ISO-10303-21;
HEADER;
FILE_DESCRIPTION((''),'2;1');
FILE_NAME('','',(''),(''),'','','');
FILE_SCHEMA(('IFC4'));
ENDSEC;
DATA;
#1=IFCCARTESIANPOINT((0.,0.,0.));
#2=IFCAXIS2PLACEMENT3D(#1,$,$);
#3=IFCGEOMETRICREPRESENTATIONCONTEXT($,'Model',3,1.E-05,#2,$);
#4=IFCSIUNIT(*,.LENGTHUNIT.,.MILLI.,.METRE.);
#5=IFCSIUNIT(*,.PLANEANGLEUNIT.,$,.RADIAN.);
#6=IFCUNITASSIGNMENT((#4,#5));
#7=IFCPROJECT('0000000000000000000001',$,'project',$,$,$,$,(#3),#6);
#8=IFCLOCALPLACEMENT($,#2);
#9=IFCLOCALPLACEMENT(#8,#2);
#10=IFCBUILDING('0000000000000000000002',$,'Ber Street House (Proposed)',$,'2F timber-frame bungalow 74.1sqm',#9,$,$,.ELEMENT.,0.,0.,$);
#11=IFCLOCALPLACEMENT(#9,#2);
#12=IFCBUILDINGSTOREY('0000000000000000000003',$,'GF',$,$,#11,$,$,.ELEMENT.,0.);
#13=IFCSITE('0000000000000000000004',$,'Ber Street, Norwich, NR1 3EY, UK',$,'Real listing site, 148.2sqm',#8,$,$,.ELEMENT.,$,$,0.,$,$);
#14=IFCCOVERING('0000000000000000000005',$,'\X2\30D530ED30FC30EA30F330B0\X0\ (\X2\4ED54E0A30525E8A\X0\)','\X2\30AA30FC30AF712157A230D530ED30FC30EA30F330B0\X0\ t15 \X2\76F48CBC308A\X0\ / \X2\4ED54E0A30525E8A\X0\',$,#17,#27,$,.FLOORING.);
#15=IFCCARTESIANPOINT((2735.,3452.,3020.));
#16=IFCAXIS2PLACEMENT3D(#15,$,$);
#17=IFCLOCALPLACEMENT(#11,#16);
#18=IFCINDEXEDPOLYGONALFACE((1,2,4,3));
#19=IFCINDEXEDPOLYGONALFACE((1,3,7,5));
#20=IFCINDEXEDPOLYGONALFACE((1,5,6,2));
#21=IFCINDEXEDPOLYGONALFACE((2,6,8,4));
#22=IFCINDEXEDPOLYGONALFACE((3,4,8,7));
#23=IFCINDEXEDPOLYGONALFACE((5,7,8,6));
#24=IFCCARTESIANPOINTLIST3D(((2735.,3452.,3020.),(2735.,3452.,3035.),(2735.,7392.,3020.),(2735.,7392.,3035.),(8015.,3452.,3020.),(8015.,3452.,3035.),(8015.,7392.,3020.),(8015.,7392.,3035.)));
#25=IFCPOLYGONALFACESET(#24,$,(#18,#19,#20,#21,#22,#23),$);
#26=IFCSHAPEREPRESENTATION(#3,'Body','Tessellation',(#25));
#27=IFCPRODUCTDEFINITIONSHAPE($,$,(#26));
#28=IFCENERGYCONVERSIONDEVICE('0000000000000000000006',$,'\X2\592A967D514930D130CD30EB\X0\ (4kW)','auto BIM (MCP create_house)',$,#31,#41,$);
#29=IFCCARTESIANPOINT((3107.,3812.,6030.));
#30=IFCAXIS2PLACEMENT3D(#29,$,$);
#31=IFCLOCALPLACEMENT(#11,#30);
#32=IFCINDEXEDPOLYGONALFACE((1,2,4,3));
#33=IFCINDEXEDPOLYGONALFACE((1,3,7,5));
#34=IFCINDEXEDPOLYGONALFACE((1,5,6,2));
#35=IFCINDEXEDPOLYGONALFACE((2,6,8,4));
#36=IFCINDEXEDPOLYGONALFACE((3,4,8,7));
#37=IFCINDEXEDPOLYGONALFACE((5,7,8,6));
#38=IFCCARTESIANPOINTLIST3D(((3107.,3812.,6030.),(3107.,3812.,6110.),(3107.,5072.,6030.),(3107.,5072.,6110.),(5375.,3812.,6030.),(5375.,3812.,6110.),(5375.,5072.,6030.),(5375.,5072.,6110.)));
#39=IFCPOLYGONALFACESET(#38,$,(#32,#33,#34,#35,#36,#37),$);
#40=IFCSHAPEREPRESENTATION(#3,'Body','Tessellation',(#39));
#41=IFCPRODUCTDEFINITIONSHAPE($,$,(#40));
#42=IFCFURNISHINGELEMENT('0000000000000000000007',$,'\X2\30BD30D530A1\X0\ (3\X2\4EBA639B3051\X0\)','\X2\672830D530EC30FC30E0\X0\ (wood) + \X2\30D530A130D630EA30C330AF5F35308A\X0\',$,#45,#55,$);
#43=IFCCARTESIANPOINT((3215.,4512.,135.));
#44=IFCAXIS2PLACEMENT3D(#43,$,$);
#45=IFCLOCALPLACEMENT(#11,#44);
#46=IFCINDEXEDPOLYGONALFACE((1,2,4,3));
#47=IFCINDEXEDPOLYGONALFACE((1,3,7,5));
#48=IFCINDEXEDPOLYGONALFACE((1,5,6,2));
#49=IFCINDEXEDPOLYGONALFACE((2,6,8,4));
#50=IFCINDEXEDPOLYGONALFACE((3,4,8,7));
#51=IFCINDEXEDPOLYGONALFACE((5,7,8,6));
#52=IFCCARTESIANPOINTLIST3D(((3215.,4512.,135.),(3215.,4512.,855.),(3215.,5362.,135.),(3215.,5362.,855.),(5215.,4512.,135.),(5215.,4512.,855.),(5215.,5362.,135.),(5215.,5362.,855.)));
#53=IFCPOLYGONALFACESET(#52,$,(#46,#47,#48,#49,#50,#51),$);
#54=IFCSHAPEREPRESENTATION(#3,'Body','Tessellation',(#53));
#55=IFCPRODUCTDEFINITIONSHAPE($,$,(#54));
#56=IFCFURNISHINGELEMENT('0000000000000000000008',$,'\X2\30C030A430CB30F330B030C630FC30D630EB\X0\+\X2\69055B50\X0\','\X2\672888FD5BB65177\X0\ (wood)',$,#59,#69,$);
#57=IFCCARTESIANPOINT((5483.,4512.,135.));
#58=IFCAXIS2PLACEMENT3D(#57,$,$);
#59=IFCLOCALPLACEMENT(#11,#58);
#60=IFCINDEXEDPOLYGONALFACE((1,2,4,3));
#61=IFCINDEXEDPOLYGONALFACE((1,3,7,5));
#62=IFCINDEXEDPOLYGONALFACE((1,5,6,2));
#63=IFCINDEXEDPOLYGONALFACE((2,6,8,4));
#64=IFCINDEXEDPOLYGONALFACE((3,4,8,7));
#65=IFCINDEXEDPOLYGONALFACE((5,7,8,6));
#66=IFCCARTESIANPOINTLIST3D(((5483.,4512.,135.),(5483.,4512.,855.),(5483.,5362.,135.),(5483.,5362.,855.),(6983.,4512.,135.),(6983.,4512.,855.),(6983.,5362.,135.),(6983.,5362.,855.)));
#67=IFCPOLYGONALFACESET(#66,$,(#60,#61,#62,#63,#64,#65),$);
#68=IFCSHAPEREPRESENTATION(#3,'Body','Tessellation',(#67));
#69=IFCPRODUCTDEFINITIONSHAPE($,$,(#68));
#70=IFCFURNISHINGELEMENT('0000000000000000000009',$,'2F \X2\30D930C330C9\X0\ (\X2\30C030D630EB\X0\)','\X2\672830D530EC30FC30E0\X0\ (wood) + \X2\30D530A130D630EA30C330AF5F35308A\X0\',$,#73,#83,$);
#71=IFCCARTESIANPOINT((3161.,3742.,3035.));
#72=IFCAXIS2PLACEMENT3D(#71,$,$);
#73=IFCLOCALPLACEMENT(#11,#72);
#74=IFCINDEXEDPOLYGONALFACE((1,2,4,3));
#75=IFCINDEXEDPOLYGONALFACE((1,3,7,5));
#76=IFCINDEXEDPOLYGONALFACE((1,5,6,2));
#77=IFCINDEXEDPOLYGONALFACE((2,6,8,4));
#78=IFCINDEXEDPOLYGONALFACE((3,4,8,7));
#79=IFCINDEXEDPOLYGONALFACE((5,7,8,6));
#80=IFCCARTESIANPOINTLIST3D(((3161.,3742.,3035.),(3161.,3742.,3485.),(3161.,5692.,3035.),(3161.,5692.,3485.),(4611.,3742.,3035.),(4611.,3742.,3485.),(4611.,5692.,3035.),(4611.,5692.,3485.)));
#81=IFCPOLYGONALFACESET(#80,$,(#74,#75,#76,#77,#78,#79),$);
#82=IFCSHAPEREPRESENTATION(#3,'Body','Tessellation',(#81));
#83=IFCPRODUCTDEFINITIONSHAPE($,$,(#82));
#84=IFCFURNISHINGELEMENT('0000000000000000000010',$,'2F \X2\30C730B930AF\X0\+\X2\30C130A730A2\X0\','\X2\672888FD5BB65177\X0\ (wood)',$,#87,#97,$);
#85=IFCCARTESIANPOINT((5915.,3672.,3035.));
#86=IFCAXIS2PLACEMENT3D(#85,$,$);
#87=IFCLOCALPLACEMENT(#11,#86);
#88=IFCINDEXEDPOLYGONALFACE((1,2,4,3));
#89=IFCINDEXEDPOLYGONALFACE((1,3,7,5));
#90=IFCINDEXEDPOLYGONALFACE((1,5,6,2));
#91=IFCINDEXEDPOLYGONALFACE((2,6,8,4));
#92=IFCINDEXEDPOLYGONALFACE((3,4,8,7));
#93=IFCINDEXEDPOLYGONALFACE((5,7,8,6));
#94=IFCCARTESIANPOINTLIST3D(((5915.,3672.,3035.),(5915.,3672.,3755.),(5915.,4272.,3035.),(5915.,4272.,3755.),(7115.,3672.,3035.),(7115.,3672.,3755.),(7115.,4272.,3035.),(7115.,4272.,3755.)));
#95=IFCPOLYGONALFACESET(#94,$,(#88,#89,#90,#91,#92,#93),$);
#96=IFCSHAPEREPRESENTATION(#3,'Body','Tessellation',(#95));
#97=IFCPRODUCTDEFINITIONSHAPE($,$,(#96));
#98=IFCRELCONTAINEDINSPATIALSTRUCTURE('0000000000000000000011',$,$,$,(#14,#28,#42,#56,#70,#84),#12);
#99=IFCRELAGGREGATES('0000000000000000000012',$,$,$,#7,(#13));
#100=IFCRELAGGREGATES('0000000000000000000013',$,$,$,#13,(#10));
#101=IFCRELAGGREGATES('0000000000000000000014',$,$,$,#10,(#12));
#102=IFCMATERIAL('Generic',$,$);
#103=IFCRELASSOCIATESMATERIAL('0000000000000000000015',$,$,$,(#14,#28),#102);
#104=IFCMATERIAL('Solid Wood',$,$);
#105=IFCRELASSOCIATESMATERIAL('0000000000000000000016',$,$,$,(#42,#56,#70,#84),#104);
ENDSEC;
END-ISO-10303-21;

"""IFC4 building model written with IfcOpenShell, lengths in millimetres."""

from ifc_helpers import new_model, si_unit, frame, frame_2d, origin, place, context, project, spatial, rectangle, extrude, material, element, save


model = new_model("IFC4")

# Units and contexts
model_context = context("Model", 3, precision=1e-05, world=origin())
ifc_project = project(units=[si_unit("LENGTHUNIT", "METRE", prefix="MILLI"), si_unit("PLANEANGLEUNIT", "RADIAN")], contexts=[model_context])

# Site, building, storey
site_placement = place(None, origin())
site = spatial("IfcSite", under=ifc_project, at=site_placement, Name="Ber Street, Norwich, NR1 3EY, UK", ObjectType="Real listing site, 148.2sqm", CompositionType="ELEMENT", RefElevation=0.0)
building_placement = place(site_placement, origin())
building = spatial("IfcBuilding", under=site, at=building_placement, Name="Ber Street House (Proposed)", ObjectType="2F timber-frame bungalow 74.1sqm", CompositionType="ELEMENT", ElevationOfRefHeight=0.0, ElevationOfTerrain=0.0)
storey_placement = place(building_placement, origin())
storey = spatial("IfcBuildingStorey", under=building, at=storey_placement, Name="GF", CompositionType="ELEMENT", Elevation=0.0)

# Shared definitions
ifc_material_1 = material(Name="Solid Wood")

# Covering
ifc_material_2 = material(Name="Generic")
covering_placement = place(storey_placement, frame((2735.0, 3452.0, 3020.0)))
element("IfcCovering", 1, at=covering_placement, inside=storey, material=ifc_material_2, Name="フローリング (仕上げ床)", Description="オーク無垢フローリング t15 直貼り / 仕上げ床", PredefinedType="FLOORING", context=model_context, shape_type="SweptSolid", body=[
    extrude(rectangle(XDim=5280.0, YDim=3940.0, at=frame_2d((2640.0, 1970.0))), frame((2735.0, 3452.0, 3020.0)), (0.0, 0.0, 1.0), 15.0),
])

# Energy conversion device
energy_conversion_device_placement = place(storey_placement, frame((3107.0, 3812.0, 6030.0)))
element("IfcEnergyConversionDevice", 2, at=energy_conversion_device_placement, inside=storey, material=ifc_material_2, Name="太陽光パネル (4kW)", Description="auto BIM (MCP create_house)", context=model_context, shape_type="SweptSolid", body=[
    extrude(rectangle(XDim=2268.0, YDim=1260.0, at=frame_2d((1134.0, 630.0))), frame((3107.0, 3812.0, 6030.0)), (0.0, 0.0, 1.0), 80.0),
])

# Furnishing elements
furnishing_1_placement = place(storey_placement, frame((3215.0, 4512.0, 135.0)))
element("IfcFurnishingElement", 3, at=furnishing_1_placement, inside=storey, material=ifc_material_1, Name="ソファ (3人掛け)", Description="木フレーム (wood) + ファブリック張り", context=model_context, shape_type="SweptSolid", body=[
    extrude(rectangle(XDim=2000.0, YDim=850.0, at=frame_2d((1000.0, 425.0))), frame((3215.0, 4512.0, 135.0)), (0.0, 0.0, 1.0), 720.0),
])
furnishing_2_placement = place(storey_placement, frame((5483.0, 4512.0, 135.0)))
element("IfcFurnishingElement", 4, at=furnishing_2_placement, inside=storey, material=ifc_material_1, Name="ダイニングテーブル+椅子", Description="木製家具 (wood)", context=model_context, shape_type="SweptSolid", body=[
    extrude(rectangle(XDim=1500.0, YDim=850.0, at=frame_2d((750.0, 425.0))), frame((5483.0, 4512.0, 135.0)), (0.0, 0.0, 1.0), 720.0),
])
furnishing_3_placement = place(storey_placement, frame((3161.0, 3742.0, 3035.0)))
element("IfcFurnishingElement", 5, at=furnishing_3_placement, inside=storey, material=ifc_material_1, Name="2F ベッド (ダブル)", Description="木フレーム (wood) + ファブリック張り", context=model_context, shape_type="SweptSolid", body=[
    extrude(rectangle(XDim=1450.0, YDim=1950.0, at=frame_2d((725.0, 975.0))), frame((3161.0, 3742.0, 3035.0)), (0.0, 0.0, 1.0), 450.0),
])
furnishing_4_placement = place(storey_placement, frame((5915.0, 3672.0, 3035.0)))
element("IfcFurnishingElement", 6, at=furnishing_4_placement, inside=storey, material=ifc_material_1, Name="2F デスク+チェア", Description="木製家具 (wood)", context=model_context, shape_type="SweptSolid", body=[
    extrude(rectangle(XDim=1200.0, YDim=600.0, at=frame_2d((600.0, 300.0))), frame((5915.0, 3672.0, 3035.0)), (0.0, 0.0, 1.0), 720.0),
])

save(model, "model.ifc")
